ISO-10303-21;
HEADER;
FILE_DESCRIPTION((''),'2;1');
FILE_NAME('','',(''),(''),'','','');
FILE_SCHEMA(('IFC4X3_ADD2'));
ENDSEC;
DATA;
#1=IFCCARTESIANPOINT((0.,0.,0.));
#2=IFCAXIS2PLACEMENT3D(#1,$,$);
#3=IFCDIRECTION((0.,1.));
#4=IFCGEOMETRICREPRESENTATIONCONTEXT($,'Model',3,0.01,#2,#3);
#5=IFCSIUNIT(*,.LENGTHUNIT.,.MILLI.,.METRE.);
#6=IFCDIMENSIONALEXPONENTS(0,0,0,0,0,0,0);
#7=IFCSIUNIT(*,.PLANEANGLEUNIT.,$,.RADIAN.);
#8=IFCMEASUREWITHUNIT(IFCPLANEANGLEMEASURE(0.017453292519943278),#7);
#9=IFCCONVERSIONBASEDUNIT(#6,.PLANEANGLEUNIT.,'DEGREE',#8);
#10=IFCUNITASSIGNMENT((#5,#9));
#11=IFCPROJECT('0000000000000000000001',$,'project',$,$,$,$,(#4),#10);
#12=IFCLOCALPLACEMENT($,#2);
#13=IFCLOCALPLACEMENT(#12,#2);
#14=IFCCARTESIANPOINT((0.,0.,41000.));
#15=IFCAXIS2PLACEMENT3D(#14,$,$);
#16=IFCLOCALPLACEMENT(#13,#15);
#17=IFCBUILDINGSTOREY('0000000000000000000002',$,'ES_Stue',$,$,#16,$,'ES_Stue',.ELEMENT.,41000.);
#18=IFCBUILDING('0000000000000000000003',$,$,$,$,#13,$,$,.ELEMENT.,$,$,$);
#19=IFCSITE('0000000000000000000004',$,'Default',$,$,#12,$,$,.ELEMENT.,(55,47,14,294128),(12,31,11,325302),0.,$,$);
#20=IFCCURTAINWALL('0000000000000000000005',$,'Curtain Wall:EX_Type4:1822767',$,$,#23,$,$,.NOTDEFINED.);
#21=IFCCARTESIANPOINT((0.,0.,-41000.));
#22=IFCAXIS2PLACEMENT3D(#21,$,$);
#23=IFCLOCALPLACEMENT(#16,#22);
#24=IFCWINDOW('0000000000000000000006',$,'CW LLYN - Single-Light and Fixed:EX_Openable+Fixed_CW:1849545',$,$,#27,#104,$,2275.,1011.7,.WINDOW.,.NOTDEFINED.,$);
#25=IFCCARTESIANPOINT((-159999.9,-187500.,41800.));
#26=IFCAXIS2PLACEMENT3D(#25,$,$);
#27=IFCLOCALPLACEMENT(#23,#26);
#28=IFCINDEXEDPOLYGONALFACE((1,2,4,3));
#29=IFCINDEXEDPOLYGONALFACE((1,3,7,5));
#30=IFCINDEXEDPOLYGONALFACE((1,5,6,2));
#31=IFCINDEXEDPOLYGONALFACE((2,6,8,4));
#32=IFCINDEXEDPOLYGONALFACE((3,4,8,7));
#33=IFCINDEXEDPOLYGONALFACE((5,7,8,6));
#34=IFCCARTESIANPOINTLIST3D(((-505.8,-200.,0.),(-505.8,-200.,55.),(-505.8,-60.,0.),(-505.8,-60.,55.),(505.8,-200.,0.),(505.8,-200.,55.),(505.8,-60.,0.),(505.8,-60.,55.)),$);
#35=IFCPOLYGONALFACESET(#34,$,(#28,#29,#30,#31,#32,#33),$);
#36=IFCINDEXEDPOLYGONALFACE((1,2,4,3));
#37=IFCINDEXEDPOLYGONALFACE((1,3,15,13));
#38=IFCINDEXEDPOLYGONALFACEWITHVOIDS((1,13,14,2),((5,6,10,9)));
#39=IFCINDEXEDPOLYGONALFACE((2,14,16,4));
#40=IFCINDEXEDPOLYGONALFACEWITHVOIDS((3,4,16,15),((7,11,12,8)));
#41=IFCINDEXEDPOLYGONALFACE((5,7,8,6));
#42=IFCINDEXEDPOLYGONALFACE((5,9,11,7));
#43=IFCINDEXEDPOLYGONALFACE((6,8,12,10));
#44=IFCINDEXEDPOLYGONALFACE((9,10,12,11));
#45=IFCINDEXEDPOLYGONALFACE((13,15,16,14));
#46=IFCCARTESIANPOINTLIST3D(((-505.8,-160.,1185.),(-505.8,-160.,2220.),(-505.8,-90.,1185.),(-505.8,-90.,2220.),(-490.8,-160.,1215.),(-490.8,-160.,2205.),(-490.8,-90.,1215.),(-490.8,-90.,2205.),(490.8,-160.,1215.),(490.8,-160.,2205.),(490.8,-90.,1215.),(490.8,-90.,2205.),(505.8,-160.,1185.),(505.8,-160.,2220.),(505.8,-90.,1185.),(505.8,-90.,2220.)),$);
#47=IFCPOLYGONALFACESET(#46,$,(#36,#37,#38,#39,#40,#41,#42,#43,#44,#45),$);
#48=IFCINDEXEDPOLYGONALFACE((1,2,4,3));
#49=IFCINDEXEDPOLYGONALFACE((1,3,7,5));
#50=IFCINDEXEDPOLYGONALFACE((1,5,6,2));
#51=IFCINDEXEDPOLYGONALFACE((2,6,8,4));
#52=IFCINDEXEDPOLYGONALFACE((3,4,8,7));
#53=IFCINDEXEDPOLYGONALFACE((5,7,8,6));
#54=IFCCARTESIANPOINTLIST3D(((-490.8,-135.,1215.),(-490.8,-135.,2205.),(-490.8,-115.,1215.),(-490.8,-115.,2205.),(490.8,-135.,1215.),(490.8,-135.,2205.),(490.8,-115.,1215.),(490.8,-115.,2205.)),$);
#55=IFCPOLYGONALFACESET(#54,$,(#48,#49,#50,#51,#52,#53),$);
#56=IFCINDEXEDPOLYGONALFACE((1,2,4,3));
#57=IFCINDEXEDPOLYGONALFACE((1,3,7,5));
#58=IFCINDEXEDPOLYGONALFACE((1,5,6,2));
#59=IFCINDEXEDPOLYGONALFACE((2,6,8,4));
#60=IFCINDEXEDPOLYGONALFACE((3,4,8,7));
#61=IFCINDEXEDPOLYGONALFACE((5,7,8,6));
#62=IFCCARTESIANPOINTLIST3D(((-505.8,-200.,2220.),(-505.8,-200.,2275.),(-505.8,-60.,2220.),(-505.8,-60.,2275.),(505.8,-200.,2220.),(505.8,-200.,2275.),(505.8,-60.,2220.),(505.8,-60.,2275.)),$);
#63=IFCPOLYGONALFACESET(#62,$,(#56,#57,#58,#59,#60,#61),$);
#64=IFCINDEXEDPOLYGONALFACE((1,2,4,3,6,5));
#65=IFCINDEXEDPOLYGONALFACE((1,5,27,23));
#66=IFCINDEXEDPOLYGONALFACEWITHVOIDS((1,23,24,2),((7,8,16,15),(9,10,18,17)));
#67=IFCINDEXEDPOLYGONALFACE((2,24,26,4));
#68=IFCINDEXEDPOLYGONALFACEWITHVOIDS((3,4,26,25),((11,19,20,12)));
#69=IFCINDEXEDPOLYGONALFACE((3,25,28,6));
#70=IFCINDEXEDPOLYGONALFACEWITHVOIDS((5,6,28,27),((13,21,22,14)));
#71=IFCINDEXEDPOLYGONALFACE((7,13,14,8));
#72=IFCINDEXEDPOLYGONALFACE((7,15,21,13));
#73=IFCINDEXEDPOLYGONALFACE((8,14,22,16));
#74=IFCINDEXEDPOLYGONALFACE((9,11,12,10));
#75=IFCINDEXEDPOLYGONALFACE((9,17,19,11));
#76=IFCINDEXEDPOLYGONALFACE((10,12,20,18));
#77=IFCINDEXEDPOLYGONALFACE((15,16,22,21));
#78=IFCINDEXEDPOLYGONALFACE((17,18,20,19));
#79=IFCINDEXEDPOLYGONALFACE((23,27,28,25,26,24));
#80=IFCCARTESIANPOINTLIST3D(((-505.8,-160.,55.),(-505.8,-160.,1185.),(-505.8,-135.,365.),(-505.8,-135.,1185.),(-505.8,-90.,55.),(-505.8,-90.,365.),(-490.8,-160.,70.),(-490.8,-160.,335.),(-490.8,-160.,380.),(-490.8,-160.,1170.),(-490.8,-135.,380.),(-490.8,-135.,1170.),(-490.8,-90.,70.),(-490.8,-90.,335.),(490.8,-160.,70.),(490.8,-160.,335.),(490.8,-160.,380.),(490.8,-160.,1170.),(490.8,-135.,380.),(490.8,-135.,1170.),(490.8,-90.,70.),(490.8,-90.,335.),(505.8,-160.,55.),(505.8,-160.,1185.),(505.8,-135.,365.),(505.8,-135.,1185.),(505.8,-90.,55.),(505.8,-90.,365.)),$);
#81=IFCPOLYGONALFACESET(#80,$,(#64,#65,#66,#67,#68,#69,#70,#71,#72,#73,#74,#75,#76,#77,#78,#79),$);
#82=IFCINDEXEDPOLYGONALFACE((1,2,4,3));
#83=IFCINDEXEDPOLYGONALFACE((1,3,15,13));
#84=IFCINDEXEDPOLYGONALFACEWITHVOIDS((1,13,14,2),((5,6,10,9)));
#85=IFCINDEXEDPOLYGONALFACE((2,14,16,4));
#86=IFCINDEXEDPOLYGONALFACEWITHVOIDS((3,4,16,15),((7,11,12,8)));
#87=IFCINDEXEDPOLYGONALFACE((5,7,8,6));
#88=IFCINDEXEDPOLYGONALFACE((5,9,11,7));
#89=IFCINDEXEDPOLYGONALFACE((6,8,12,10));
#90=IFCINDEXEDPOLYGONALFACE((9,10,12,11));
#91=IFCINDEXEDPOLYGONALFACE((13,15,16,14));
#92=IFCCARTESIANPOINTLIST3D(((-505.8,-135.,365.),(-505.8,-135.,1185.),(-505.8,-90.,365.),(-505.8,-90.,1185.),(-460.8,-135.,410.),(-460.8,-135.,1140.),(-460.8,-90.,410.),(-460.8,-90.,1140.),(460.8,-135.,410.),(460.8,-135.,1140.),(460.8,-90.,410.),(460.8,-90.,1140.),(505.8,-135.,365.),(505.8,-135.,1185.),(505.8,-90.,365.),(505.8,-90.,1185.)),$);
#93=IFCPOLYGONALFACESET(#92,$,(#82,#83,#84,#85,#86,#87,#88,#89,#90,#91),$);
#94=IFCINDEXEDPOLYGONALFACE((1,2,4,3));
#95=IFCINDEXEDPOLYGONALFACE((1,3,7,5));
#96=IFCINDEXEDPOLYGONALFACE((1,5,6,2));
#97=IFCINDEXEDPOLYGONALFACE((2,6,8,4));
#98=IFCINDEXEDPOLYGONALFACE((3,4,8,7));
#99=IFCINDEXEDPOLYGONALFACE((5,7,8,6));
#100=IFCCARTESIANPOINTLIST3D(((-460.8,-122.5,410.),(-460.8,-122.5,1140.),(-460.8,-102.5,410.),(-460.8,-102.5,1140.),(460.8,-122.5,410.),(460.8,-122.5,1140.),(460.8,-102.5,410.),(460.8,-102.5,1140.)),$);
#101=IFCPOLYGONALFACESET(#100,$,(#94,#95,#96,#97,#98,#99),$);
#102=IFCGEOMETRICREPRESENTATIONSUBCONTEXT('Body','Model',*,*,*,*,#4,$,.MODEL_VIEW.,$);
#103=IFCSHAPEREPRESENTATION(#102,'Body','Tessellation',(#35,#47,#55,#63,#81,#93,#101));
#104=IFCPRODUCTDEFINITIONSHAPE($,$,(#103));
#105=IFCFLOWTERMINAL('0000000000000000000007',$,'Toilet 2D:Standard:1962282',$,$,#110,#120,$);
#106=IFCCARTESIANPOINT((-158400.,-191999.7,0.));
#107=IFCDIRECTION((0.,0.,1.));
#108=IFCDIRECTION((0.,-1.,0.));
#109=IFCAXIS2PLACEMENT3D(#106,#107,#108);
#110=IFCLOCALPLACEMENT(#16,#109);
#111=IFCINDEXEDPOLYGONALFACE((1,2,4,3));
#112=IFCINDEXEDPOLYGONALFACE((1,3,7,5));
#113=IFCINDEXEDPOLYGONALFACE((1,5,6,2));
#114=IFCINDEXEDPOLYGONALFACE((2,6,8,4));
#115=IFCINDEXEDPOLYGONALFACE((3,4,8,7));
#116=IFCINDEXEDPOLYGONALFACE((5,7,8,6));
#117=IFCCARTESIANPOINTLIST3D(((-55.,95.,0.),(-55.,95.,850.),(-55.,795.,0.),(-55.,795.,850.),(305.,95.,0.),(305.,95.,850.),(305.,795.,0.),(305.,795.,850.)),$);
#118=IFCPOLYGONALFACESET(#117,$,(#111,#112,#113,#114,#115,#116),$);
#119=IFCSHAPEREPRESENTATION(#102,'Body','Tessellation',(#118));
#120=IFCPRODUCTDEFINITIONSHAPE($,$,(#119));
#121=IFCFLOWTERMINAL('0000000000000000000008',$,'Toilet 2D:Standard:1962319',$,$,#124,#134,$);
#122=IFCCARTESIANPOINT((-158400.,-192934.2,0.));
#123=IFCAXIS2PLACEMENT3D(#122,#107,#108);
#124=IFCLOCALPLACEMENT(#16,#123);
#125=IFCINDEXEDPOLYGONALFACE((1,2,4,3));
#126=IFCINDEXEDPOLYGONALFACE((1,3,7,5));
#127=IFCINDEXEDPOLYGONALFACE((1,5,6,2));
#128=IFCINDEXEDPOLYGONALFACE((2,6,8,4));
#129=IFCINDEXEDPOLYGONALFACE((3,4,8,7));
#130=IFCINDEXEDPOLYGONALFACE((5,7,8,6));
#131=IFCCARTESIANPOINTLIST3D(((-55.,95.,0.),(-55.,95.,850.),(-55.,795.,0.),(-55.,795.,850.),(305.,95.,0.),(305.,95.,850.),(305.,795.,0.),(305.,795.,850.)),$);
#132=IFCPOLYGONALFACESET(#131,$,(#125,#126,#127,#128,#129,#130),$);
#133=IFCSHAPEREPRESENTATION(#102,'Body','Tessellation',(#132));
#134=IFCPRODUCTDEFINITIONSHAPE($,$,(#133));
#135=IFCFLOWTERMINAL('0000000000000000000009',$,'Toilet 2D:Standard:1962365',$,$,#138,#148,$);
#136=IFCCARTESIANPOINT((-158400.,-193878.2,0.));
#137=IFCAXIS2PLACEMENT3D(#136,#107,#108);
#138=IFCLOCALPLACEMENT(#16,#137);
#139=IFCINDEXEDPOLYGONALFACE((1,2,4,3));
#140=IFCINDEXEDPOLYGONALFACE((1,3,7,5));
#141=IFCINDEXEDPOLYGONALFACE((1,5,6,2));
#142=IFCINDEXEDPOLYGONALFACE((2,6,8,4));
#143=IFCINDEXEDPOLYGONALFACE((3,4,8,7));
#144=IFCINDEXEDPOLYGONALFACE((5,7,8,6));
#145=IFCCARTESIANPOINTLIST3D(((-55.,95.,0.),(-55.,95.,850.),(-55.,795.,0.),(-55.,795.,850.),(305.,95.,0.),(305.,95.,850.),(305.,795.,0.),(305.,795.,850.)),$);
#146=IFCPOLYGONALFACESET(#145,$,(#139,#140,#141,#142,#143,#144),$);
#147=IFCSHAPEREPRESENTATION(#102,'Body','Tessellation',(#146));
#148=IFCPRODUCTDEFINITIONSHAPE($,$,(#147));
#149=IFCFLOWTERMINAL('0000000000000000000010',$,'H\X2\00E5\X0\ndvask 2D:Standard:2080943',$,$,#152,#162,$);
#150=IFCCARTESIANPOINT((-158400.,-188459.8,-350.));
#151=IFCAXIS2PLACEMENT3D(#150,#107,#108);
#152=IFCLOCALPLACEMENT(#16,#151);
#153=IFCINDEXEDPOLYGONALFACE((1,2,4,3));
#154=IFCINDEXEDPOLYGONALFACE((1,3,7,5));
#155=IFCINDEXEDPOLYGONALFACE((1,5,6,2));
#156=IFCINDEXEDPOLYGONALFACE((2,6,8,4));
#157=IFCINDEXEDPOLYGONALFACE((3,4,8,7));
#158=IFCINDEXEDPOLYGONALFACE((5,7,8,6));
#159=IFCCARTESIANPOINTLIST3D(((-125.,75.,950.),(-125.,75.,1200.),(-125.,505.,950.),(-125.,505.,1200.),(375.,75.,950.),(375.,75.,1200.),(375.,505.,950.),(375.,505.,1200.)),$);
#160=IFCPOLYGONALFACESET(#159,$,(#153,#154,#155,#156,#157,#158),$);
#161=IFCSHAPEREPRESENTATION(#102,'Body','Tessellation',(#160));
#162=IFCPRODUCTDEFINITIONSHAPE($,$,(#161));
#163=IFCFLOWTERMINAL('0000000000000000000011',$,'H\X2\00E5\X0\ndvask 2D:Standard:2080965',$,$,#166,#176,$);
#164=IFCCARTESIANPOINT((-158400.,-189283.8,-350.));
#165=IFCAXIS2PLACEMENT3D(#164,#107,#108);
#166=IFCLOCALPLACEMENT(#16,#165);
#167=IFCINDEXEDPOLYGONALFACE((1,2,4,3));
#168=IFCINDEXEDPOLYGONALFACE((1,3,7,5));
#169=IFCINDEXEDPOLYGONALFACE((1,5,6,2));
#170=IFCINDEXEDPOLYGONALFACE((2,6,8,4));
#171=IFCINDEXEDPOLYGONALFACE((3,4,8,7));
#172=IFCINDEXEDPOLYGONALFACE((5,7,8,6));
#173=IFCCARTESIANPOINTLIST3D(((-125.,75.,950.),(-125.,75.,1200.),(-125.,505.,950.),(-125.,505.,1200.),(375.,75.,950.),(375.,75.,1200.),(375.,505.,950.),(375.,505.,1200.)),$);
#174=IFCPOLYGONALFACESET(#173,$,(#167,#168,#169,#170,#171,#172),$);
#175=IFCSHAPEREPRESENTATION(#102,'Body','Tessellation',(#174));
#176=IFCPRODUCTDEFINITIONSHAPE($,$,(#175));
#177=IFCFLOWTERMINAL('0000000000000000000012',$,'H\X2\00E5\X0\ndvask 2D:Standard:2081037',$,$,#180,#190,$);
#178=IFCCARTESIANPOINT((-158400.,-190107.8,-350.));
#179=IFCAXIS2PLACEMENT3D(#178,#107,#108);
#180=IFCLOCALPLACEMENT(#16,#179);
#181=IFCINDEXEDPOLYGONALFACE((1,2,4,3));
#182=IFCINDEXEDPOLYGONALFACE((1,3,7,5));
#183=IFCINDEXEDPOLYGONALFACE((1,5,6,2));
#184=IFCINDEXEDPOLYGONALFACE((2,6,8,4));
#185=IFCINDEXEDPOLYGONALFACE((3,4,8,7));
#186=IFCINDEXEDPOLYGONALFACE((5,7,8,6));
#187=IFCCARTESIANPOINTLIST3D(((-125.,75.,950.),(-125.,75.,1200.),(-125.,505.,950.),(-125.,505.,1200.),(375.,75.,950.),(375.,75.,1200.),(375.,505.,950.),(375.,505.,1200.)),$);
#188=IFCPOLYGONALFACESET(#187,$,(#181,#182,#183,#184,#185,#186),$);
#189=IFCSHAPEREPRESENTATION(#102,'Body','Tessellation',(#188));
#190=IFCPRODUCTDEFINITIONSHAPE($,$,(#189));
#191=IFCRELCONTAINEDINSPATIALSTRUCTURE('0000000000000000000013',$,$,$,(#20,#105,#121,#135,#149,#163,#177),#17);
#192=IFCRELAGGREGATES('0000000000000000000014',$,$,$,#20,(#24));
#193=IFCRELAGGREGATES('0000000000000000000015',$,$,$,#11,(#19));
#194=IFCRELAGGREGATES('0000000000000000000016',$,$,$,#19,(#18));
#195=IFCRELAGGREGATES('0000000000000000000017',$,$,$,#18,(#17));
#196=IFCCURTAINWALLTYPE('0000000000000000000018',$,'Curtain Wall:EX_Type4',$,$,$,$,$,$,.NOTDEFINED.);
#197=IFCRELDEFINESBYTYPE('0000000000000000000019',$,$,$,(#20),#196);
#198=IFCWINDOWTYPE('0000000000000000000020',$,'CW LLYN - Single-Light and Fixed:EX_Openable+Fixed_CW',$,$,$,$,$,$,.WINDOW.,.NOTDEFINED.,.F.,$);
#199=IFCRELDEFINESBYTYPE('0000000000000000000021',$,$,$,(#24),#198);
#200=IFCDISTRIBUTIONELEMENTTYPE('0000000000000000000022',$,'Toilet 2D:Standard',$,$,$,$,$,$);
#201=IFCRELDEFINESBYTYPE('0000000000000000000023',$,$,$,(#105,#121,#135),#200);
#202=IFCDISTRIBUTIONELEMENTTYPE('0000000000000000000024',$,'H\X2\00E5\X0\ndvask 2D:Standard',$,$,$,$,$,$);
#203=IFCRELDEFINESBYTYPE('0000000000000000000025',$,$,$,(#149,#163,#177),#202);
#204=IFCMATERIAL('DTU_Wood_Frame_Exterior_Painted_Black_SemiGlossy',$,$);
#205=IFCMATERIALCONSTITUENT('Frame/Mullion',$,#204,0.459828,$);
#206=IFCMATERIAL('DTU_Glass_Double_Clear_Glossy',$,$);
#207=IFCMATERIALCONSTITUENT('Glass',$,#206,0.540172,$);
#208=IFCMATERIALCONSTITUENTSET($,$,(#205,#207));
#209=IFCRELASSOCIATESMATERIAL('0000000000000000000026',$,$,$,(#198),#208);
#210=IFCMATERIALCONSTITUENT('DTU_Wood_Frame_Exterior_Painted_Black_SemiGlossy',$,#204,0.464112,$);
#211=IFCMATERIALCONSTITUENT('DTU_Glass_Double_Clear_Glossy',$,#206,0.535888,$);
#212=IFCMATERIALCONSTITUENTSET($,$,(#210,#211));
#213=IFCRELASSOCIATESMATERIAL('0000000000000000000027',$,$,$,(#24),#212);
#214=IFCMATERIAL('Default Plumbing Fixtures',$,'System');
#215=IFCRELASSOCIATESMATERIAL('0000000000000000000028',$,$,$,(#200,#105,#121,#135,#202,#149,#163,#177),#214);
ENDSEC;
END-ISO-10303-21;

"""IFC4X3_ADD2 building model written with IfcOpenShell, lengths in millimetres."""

from ifc_helpers import new_model, entity, si_unit, converted_unit, direction, frame, frame_2d, origin, origin_2d_with_axis, place, context, subcontext, project, spatial, polyline, rectangle, outline, extrude, source, transform, mapped, material, constituent, constituent_set, type_object, type_shapes, element, aggregate, save


model = new_model("IFC4X3_ADD2")

# Units and contexts
model_context = context("Model", 3, precision=0.01, world=origin(), true_north=direction((0.0, 1.0)))
body_context = subcontext(model_context, "Body", "Model", "MODEL_VIEW")
ifc_project = project(units=[si_unit("LENGTHUNIT", "METRE", prefix="MILLI"), converted_unit("PLANEANGLEUNIT", "DEGREE", entity("IfcPlaneAngleMeasure", 0.017453292519943278), si_unit("PLANEANGLEUNIT", "RADIAN"), dimensions=[0, 0, 0, 0, 0, 0, 0])], contexts=[model_context])

# Site, building, storey
site_placement = place(None, origin())
site = spatial("IfcSite", under=ifc_project, at=site_placement, Name="Default", CompositionType="ELEMENT", RefLatitude=(55, 47, 14, 294128), RefLongitude=(12, 31, 11, 325302), RefElevation=0.0)
building_placement = place(site_placement, origin())
building = spatial("IfcBuilding", under=site, at=building_placement, CompositionType="ELEMENT")
storey_placement = place(building_placement, frame((0.0, 0.0, 41000.0)))
storey = spatial("IfcBuildingStorey", under=building, at=storey_placement, Name="ES_Stue", LongName="ES_Stue", CompositionType="ELEMENT", Elevation=41000.0)

# Curtain wall
curtain_wall_type = type_object("IfcCurtainWallType", Name="Curtain Wall:EX_Type4", PredefinedType="NOTDEFINED")
curtain_wall_placement = place(storey_placement, frame((0.0, 0.0, -41000.0)))
curtain_wall = element("IfcCurtainWall", 1, at=curtain_wall_placement, inside=storey, type_object=curtain_wall_type, Name="Curtain Wall:EX_Type4:1822767", PredefinedType="NOTDEFINED")

# Shared definitions
ifc_material_1 = material(Name="DTU_Wood_Frame_Exterior_Painted_Black_SemiGlossy")
ifc_material_2 = material(Name="DTU_Glass_Double_Clear_Glossy")

# Window, openings
ifc_constituent_1 = constituent(ifc_material_1, Name="DTU_Wood_Frame_Exterior_Painted_Black_SemiGlossy", fraction=0.464112)
ifc_constituent_2 = constituent(ifc_material_2, Name="DTU_Glass_Double_Clear_Glossy", fraction=0.535888)
ifc_constituent_set_1 = constituent_set(constituents=[ifc_constituent_1, ifc_constituent_2])
ifc_constituent_3 = constituent(ifc_material_1, Name="Frame/Mullion", fraction=0.459828)
ifc_constituent_4 = constituent(ifc_material_2, Name="Glass", fraction=0.540172)
ifc_constituent_set_2 = constituent_set(constituents=[ifc_constituent_3, ifc_constituent_4])
window_type_1 = type_object("IfcWindowType", Name="CW LLYN - Single-Light and Fixed:EX_Openable+Fixed_CW", ParameterTakesPrecedence=False, PartitioningType="NOTDEFINED", PredefinedType="WINDOW", material=ifc_constituent_set_2)
shared_shape_1 = source(origin(), body_context, "Body", "SweptSolid", [
    extrude(rectangle(XDim=140.0, YDim=1011.7, at=origin_2d_with_axis()), frame((0.0, -130.0, 0.0), z_axis=(0.0, 0.0, 1.0), x_axis=(0.0, -1.0, 0.0)), (0.0, 0.0, 1.0), 55.0),
    extrude(outline(polyline([(-517.5, -505.8), (517.5, -505.8), (517.5, 505.8), (-517.5, 505.8), (-517.5, -505.8)]), holes=[polyline([(502.5, -490.8), (-487.5, -490.8), (-487.5, 490.8), (502.5, 490.8), (502.5, -490.8)])]), frame((0.0, -90.0, 1702.5), z_axis=(0.0, -1.0, 0.0), x_axis=(0.0, 0.0, 1.0)), (0.0, 0.0, 1.0), 70.0),
    extrude(rectangle(XDim=981.7, YDim=20.0, at=frame_2d((0.0, 0.0), x_axis=(1.0, 0.0))), frame((0.0, -125.0, 1215.0), z_axis=(0.0, 0.0, 1.0), x_axis=(-1.0, 0.0, 0.0)), (0.0, 0.0, 1.0), 990.0),
    extrude(rectangle(XDim=981.7, YDim=20.0, at=frame_2d((0.0, 0.0), x_axis=(1.0, 0.0))), frame((0.0, -125.0, 70.0), z_axis=(0.0, 0.0, 1.0), x_axis=(-1.0, 0.0, 0.0)), (0.0, 0.0, 1.0), 265.0),
    extrude(rectangle(XDim=140.0, YDim=1011.7, at=frame_2d((0.0, 0.0), x_axis=(1.0, 0.0))), frame((0.0, -130.0, 2220.0), z_axis=(0.0, 0.0, 1.0), x_axis=(0.0, -1.0, 0.0)), (0.0, 0.0, 1.0), 55.0),
    extrude(outline(polyline([(-38.3, -480.0), (31.7, -480.0), (31.7, 650.0), (6.7, 650.0), (6.7, -170.0), (-38.3, -170.0), (-38.3, -480.0)])), frame((505.8, -128.3, 535.0), z_axis=(-1.0, 0.0, 0.0), x_axis=(0.0, -1.0, 0.0)), (0.0, 0.0, 1.0), 1011.7),
    extrude(outline(polyline([(-410.0, -505.8), (410.0, -505.8), (410.0, 505.8), (-410.0, 505.8), (-410.0, -505.8)]), holes=[polyline([(-365.0, 460.8), (365.0, 460.8), (365.0, -460.8), (-365.0, -460.8), (-365.0, 460.8)])]), frame((0.0, -90.0, 775.0), z_axis=(0.0, -1.0, 0.0), x_axis=(0.0, 0.0, 1.0)), (0.0, 0.0, 1.0), 45.0),
    extrude(rectangle(XDim=921.7, YDim=20.0, at=frame_2d((0.0, 0.0), x_axis=(1.0, 0.0))), frame((0.0, -112.5, 410.0), z_axis=(0.0, 0.0, 1.0), x_axis=(-1.0, 0.0, 0.0)), (0.0, 0.0, 1.0), 730.0),
])
type_shapes(window_type_1, [shared_shape_1])
window_1_placement = place(curtain_wall_placement, frame((-159999.9, -187500.0, 41800.0)))
window_1 = element("IfcWindow", 2, at=window_1_placement, type_object=window_type_1, material=ifc_constituent_set_1, Name="CW LLYN - Single-Light and Fixed:EX_Openable+Fixed_CW:1849545", OverallHeight=2275.0, OverallWidth=1011.7, PartitioningType="NOTDEFINED", PredefinedType="WINDOW", context=body_context, shape_type="MappedRepresentation", body=[
    mapped(shared_shape_1, transform((0.0, 0.0, 0.0), scale=1.0)),
])
opening_1_placement = place(curtain_wall_placement, frame((-159999.9, -187500.0, 82800.0), z_axis=(0.0, 0.0, 1.0), x_axis=(-1.0, 0.0, 0.0)))
opening_1 = element("IfcOpeningElement", 3, at=opening_1_placement, cuts=window_1, PredefinedType="OPENING", context=body_context, shape_type="SweptSolid", body=[
    extrude(rectangle(XDim=265.0, YDim=981.7, at=frame_2d((0.0, 0.0), x_axis=(1.0, 0.0))), frame((0.0, 160.0, -40797.5), z_axis=(0.0, -1.0, 0.0), x_axis=(0.0, 0.0, 1.0)), (0.0, 0.0, 1.0), 70.0),
])
opening_2_placement = place(curtain_wall_placement, frame((-159999.9, -187500.0, 82800.0), z_axis=(0.0, 0.0, 1.0), x_axis=(-1.0, 0.0, 0.0)))
opening_2 = element("IfcOpeningElement", 4, at=opening_2_placement, cuts=window_1, PredefinedType="OPENING", context=body_context, shape_type="SweptSolid", body=[
    extrude(rectangle(XDim=790.0, YDim=981.7, at=frame_2d((0.0, 0.0), x_axis=(1.0, 0.0))), frame((0.0, 135.0, -40225.0), z_axis=(0.0, 1.0, 0.0), x_axis=(0.0, 0.0, 1.0)), (0.0, 0.0, 1.0), 25.0),
])
aggregate(curtain_wall, [window_1, opening_1, opening_2])

# Flow terminals
ifc_material_3 = material(Name="Default Plumbing Fixtures", Category="System")
distribution_element_type_1 = type_object("IfcDistributionElementType", Name="Toilet 2D:Standard", material=ifc_material_3)
shared_shape_2 = source(origin(), body_context, "Body", "SweptSolid", [
    extrude(rectangle(XDim=360.0, YDim=700.0, at=frame_2d((0.0, 0.0), x_axis=(1.0, 0.0))), frame((125.0, 445.0, 0.0), z_axis=(0.0, 0.0, 1.0), x_axis=(-1.0, 0.0, 0.0)), (0.0, 0.0, 1.0), 850.0),
])
type_shapes(distribution_element_type_1, [shared_shape_2])
for number, where, z_axis, x_axis, name in (
    (5, (-158400.0, -191999.7, 0.0), (0.0, 0.0, 1.0), (0.0, -1.0, 0.0), "Toilet 2D:Standard:1962282"),
    (6, (-158400.0, -192934.2, 0.0), (0.0, 0.0, 1.0), (0.0, -1.0, 0.0), "Toilet 2D:Standard:1962319"),
    (7, (-158400.0, -193878.2, 0.0), (0.0, 0.0, 1.0), (0.0, -1.0, 0.0), "Toilet 2D:Standard:1962365"),
):
    element("IfcFlowTerminal", number, at=place(storey_placement, frame(where, z_axis=z_axis, x_axis=x_axis)), inside=storey, type_object=distribution_element_type_1, material=ifc_material_3, Name=name, context=body_context, shape_type="MappedRepresentation", body=[
        mapped(shared_shape_2, transform((0.0, 0.0, 0.0), scale=1.0)),
    ])
distribution_element_type_2 = type_object("IfcDistributionElementType", Name="Håndvask 2D:Standard", material=ifc_material_3)
shared_shape_3 = source(origin(), body_context, "Body", "SweptSolid", [
    extrude(rectangle(XDim=500.0, YDim=430.0, at=frame_2d((0.0, 0.0), x_axis=(1.0, 0.0))), frame((125.0, 290.0, 950.0), z_axis=(0.0, 0.0, 1.0), x_axis=(-1.0, 0.0, 0.0)), (0.0, 0.0, 1.0), 250.0),
])
type_shapes(distribution_element_type_2, [shared_shape_3])
for number, where, z_axis, x_axis, name in (
    (8, (-158400.0, -188459.8, -350.0), (0.0, 0.0, 1.0), (0.0, -1.0, 0.0), "Håndvask 2D:Standard:2080943"),
    (9, (-158400.0, -189283.8, -350.0), (0.0, 0.0, 1.0), (0.0, -1.0, 0.0), "Håndvask 2D:Standard:2080965"),
    (10, (-158400.0, -190107.8, -350.0), (0.0, 0.0, 1.0), (0.0, -1.0, 0.0), "Håndvask 2D:Standard:2081037"),
):
    element("IfcFlowTerminal", number, at=place(storey_placement, frame(where, z_axis=z_axis, x_axis=x_axis)), inside=storey, type_object=distribution_element_type_2, material=ifc_material_3, Name=name, context=body_context, shape_type="MappedRepresentation", body=[
        mapped(shared_shape_3, transform((0.0, 0.0, 0.0), scale=1.0)),
    ])

save(model, "model.ifc")
